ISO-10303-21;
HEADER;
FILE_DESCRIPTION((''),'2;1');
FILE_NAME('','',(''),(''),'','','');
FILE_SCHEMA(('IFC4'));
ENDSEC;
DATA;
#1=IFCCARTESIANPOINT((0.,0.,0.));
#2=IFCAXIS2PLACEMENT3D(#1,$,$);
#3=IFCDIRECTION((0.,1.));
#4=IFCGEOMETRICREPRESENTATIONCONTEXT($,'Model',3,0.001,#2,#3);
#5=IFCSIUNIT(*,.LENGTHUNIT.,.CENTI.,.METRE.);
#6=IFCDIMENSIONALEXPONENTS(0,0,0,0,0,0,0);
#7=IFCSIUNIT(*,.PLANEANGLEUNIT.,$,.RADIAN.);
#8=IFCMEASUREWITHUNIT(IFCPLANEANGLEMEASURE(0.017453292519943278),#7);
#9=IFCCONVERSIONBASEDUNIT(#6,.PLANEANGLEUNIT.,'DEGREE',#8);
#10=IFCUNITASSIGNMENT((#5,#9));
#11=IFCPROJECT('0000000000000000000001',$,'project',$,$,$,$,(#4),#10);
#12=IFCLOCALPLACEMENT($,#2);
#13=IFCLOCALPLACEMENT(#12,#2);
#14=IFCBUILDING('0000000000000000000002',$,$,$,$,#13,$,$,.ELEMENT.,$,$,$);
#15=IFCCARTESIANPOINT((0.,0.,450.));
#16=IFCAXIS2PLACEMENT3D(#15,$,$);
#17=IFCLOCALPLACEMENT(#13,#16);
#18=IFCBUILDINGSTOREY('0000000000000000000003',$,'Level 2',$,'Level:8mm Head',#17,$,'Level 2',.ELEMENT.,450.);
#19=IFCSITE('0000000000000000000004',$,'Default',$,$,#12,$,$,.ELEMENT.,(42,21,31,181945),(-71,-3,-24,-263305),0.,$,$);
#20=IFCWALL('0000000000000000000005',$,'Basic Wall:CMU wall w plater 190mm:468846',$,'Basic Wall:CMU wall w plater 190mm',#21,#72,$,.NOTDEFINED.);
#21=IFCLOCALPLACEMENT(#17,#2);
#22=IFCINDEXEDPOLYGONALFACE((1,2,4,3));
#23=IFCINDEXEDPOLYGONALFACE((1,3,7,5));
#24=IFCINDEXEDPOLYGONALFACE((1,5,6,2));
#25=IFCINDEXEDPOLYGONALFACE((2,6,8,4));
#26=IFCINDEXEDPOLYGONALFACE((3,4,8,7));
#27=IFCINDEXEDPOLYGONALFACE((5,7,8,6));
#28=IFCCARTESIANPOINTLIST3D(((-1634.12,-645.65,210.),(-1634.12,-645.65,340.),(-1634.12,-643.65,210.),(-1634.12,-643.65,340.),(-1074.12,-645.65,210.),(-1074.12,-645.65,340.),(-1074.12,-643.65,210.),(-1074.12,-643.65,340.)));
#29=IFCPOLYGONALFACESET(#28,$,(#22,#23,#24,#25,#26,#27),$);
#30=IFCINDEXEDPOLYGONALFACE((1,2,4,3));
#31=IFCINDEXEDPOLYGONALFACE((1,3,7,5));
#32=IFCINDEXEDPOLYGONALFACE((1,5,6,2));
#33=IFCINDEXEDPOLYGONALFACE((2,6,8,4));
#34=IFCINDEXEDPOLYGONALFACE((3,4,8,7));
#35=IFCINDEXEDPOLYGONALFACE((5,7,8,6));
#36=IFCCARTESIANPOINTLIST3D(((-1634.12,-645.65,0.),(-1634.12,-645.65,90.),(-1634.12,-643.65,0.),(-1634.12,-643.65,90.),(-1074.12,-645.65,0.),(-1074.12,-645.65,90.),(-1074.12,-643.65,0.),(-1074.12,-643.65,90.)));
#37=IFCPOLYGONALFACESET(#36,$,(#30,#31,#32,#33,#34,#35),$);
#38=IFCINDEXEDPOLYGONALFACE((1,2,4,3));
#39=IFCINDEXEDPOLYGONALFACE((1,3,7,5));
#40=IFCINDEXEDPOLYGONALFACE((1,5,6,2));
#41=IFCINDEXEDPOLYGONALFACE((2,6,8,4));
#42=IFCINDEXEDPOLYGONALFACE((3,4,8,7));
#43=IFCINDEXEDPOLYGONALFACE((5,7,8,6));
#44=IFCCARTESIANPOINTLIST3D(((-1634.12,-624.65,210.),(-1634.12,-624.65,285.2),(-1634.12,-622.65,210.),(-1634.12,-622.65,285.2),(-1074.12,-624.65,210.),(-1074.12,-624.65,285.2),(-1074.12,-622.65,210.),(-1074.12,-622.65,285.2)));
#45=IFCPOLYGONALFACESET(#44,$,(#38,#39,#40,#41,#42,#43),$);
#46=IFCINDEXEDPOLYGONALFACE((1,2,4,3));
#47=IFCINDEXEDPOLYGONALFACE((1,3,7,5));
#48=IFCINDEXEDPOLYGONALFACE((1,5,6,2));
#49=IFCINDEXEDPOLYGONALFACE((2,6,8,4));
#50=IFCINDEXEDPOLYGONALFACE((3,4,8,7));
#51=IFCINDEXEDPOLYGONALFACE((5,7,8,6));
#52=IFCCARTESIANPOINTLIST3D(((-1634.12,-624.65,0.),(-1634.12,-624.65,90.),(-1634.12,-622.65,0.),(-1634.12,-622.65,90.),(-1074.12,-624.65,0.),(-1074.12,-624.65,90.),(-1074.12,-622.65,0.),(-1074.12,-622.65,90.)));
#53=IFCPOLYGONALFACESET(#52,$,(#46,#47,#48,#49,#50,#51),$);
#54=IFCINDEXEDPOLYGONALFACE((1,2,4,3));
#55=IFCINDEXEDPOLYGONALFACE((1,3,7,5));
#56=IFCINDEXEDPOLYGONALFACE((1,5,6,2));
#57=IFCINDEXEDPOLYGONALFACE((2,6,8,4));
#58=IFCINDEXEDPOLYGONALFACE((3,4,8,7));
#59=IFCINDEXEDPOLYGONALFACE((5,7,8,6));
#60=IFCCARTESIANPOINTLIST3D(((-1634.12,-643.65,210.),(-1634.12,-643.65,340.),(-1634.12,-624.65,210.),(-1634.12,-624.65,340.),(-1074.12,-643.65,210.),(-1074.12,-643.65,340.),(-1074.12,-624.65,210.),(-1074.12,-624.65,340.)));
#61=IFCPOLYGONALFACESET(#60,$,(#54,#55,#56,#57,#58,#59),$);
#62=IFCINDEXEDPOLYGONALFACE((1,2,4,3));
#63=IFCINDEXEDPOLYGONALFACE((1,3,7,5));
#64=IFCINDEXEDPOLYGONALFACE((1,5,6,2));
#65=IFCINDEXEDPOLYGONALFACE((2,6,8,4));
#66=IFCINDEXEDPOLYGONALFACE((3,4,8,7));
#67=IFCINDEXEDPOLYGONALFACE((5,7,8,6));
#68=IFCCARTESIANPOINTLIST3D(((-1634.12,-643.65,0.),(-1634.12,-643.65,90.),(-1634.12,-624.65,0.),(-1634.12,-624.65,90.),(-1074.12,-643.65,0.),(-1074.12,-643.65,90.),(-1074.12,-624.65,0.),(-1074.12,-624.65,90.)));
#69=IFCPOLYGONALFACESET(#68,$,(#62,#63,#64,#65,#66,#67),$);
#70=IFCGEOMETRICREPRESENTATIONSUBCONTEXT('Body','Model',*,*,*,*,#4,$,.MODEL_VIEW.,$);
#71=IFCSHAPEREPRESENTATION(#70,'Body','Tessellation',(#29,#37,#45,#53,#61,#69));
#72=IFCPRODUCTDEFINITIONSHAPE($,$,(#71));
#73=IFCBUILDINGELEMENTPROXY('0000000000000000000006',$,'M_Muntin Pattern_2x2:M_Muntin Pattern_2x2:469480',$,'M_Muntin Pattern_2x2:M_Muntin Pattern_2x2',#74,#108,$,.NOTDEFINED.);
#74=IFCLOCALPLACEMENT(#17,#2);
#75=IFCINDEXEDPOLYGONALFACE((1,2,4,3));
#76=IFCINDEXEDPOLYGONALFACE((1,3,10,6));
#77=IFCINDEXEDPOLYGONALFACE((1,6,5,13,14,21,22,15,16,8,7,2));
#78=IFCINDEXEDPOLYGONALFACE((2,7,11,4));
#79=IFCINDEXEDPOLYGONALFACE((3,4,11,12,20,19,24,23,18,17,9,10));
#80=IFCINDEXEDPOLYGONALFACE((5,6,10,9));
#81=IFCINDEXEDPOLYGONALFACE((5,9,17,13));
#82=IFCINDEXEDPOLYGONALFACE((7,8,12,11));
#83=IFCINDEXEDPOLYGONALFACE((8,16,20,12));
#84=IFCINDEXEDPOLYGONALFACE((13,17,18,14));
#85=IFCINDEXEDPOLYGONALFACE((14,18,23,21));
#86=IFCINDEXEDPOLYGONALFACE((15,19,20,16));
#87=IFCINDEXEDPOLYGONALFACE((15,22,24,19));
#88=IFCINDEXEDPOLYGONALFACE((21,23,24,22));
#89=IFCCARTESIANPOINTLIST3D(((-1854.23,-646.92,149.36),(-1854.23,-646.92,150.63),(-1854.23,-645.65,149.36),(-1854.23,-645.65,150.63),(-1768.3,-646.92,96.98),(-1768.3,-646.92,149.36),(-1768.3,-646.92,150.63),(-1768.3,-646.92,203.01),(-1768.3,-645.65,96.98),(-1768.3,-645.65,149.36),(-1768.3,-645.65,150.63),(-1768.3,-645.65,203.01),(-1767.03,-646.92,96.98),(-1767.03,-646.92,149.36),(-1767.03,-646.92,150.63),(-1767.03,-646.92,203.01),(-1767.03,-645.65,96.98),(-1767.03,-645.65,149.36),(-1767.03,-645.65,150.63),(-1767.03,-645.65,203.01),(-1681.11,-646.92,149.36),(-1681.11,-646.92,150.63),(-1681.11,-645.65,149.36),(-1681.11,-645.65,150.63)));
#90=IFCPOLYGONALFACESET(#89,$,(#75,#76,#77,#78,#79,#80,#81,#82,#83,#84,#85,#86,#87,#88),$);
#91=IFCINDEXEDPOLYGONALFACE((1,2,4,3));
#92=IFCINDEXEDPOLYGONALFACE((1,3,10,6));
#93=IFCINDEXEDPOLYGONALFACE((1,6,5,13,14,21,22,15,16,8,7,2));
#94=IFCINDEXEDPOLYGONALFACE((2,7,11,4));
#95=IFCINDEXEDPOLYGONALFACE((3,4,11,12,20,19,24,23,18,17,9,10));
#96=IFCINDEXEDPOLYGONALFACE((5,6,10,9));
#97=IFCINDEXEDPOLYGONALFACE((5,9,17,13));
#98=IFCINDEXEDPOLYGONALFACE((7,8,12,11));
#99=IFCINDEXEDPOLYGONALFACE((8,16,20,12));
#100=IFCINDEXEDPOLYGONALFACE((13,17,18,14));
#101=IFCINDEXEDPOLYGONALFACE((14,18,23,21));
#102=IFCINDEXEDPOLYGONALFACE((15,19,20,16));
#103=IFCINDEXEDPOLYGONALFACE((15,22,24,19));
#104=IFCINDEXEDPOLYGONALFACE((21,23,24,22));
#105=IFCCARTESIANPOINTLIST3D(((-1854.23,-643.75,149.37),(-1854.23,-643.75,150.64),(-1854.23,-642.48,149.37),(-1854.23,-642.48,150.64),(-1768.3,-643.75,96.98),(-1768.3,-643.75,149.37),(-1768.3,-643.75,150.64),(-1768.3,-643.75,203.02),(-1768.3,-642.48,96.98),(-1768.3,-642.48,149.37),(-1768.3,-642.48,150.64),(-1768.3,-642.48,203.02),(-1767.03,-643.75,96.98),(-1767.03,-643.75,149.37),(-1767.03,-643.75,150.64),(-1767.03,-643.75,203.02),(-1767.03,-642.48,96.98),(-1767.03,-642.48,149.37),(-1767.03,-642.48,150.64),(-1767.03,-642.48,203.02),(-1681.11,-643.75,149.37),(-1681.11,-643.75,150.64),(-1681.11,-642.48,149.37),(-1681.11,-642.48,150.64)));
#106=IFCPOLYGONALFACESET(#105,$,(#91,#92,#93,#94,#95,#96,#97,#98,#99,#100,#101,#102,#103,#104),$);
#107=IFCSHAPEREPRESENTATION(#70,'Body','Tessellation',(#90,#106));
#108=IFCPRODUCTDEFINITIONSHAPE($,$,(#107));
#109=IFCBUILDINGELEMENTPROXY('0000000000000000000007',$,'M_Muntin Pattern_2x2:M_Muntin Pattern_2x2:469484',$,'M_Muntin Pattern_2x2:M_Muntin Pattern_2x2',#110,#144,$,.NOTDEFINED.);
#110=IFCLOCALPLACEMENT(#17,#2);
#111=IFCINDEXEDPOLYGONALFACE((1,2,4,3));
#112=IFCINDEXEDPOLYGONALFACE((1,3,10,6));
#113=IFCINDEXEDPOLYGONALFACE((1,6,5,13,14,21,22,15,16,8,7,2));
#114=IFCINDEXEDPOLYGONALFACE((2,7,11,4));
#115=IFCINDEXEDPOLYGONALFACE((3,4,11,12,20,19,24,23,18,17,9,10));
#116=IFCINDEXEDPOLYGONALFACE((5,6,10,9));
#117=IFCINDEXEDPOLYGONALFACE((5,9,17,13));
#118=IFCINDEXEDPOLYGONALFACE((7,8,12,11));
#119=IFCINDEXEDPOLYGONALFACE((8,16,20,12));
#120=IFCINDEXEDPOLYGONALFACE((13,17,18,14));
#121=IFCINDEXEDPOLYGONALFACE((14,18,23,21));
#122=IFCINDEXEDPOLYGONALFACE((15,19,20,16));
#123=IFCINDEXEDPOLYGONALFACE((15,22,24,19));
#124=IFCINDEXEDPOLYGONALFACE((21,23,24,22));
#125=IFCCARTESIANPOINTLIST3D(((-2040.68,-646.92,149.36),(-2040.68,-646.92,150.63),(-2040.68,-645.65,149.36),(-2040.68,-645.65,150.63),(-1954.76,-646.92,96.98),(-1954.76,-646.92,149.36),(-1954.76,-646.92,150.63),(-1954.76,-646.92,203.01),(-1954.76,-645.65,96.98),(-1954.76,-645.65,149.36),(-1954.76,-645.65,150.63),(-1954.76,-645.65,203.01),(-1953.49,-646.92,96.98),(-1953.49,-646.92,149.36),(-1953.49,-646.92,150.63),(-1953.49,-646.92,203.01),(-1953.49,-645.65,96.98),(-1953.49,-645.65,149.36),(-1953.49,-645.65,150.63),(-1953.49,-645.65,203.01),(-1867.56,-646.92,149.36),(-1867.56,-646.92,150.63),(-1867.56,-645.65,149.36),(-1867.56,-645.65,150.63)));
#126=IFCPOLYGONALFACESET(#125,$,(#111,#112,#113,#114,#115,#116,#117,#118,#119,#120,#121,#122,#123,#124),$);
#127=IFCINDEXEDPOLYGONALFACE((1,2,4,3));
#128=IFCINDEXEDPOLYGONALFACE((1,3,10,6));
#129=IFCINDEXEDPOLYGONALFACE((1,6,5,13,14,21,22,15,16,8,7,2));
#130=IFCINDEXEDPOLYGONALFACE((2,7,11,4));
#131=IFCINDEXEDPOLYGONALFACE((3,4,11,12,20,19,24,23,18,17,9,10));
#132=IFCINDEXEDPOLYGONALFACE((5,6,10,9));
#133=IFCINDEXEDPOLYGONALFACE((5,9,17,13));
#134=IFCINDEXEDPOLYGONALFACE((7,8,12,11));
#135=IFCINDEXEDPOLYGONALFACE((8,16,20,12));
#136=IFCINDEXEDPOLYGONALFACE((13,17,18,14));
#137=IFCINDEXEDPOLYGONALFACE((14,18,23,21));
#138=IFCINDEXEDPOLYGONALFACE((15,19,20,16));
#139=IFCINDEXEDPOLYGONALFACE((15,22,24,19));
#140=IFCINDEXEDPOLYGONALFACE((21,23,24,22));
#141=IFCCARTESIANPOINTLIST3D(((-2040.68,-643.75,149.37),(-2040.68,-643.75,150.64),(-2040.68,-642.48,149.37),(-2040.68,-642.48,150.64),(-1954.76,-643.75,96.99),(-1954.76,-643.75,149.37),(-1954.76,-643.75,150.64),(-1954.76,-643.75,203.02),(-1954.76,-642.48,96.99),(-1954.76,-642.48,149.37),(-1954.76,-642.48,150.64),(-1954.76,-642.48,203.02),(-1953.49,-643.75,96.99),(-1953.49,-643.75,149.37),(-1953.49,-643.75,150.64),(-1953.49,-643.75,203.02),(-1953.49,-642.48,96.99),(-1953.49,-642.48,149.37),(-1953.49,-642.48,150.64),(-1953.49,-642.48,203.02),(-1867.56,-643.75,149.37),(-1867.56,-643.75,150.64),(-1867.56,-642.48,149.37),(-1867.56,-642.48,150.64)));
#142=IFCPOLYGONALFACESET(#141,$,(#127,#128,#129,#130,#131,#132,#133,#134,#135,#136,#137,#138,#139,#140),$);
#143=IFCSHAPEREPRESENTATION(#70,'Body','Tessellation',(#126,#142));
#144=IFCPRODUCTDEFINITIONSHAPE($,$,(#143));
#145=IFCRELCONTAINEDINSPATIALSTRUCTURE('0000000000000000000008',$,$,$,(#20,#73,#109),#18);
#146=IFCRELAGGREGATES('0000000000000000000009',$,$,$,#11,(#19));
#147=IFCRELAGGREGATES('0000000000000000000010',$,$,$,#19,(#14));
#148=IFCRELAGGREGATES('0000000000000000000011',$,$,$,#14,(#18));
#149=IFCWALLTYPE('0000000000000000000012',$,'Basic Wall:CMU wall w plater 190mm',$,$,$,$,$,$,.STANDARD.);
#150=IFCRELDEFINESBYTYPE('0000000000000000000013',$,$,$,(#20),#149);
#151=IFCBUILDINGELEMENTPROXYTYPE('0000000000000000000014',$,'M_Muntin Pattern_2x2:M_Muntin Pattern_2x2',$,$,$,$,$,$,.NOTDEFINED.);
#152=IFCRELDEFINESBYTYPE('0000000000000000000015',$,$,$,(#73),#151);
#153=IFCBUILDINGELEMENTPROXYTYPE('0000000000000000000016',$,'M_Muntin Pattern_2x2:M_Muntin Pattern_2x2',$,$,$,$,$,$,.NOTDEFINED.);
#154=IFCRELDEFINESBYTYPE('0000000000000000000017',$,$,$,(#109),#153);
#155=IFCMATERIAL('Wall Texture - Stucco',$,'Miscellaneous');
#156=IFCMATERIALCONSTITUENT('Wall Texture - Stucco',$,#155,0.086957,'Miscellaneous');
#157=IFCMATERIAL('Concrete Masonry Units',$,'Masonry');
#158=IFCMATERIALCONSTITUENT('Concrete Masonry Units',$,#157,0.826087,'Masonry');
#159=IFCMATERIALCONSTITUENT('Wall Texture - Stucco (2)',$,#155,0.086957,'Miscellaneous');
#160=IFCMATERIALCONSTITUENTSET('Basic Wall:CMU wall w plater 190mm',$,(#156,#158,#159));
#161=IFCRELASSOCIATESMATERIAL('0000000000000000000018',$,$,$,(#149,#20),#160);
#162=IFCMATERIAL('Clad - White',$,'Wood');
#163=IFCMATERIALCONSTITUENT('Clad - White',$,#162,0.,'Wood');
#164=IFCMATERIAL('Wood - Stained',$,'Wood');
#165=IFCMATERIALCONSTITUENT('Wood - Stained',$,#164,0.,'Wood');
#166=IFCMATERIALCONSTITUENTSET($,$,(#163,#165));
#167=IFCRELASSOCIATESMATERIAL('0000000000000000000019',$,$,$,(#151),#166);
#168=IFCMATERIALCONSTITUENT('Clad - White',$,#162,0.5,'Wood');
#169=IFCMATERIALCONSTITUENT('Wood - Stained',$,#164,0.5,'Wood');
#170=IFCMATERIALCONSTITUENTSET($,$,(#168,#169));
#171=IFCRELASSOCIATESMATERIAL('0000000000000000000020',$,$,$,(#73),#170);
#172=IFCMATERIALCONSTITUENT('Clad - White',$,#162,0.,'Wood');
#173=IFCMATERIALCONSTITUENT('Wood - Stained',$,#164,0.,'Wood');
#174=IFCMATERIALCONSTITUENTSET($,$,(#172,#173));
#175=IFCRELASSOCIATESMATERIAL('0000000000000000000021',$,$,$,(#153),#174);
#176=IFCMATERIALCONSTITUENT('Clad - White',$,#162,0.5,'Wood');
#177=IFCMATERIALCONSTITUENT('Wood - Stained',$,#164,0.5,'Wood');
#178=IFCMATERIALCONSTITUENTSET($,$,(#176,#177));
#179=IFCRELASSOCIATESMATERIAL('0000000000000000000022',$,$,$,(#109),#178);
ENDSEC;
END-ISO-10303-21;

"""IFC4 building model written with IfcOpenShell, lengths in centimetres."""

from ifc_helpers import new_model, entity, si_unit, converted_unit, direction, frame, origin, place, context, subcontext, project, spatial, indexed_curve, outline, extrude, source, transform, mapped, material, constituent, constituent_set, type_object, type_shapes, element, save


model = new_model("IFC4")

# Units and contexts
model_context = context("Model", 3, precision=0.001, world=origin(), true_north=direction((0.0, 1.0)))
body_context = subcontext(model_context, "Body", "Model", "MODEL_VIEW")
ifc_project = project(units=[si_unit("LENGTHUNIT", "METRE", prefix="CENTI"), converted_unit("PLANEANGLEUNIT", "DEGREE", entity("IfcPlaneAngleMeasure", 0.017453292519943278), si_unit("PLANEANGLEUNIT", "RADIAN"), dimensions=[0, 0, 0, 0, 0, 0, 0])], contexts=[model_context])

# Site, building, storey
site_placement = place(None, origin())
site = spatial("IfcSite", under=ifc_project, at=site_placement, Name="Default", CompositionType="ELEMENT", RefLatitude=(42, 21, 31, 181945), RefLongitude=(-71, -3, -24, -263305), RefElevation=0.0)
building_placement = place(site_placement, origin())
building = spatial("IfcBuilding", under=site, at=building_placement, CompositionType="ELEMENT")
storey_placement = place(building_placement, frame((0.0, 0.0, 450.0)))
storey = spatial("IfcBuildingStorey", under=building, at=storey_placement, Name="Level 2", ObjectType="Level:8mm Head", LongName="Level 2", CompositionType="ELEMENT", Elevation=450.0)

# Wall, opening
ifc_material_1 = material(Name="Wall Texture - Stucco", Category="Miscellaneous")
ifc_constituent_1 = constituent(ifc_material_1, Name="Wall Texture - Stucco", Category="Miscellaneous", fraction=0.086957)
ifc_material_2 = material(Name="Concrete Masonry Units", Category="Masonry")
ifc_constituent_2 = constituent(ifc_material_2, Name="Concrete Masonry Units", Category="Masonry", fraction=0.826087)
ifc_constituent_3 = constituent(ifc_material_1, Name="Wall Texture - Stucco (2)", Category="Miscellaneous", fraction=0.086957)
ifc_constituent_set_1 = constituent_set(constituents=[ifc_constituent_1, ifc_constituent_2, ifc_constituent_3], Name="Basic Wall:CMU wall w plater 190mm")
wall_type_1 = type_object("IfcWallType", Name="Basic Wall:CMU wall w plater 190mm", PredefinedType="STANDARD", material=ifc_constituent_set_1)
wall_1_placement = place(storey_placement, frame((-1634.12, -634.15, 0.0)))
wall_1 = element("IfcWall", 1, at=wall_1_placement, inside=storey, type_object=wall_type_1, material=ifc_constituent_set_1, Name="Basic Wall:CMU wall w plater 190mm:468846", ObjectType="Basic Wall:CMU wall w plater 190mm", PredefinedType="NOTDEFINED", context=body_context, shape_type="SweptSolid", body=[
    extrude(outline(indexed_curve([(-278.0, -0.67), (278.0, -0.67), (280.0, -0.67), (280.0, 1.33), (-280.0, 1.33), (-280.0, -0.67), (-278.0, -0.67)], self_intersect=False)), frame((280.0, -10.83, 210.0)), (0.0, 0.0, 1.0), 130.0),
    extrude(outline(indexed_curve([(-1.0, -280.0), (1.0, -280.0), (1.0, 280.0), (-1.0, 280.0), (-1.0, -280.0)], self_intersect=False)), frame((280.0, -10.5, 0.0), z_axis=(0.0, 0.0, 1.0), x_axis=(0.0, 1.0, 0.0)), (0.0, 0.0, 1.0), 90.0),
    extrude(outline(indexed_curve([(-1.0, -37.6), (1.0, -37.6), (1.0, 37.6), (-1.0, 37.6), (-1.0, -37.6)], self_intersect=False)), frame((0.0, 10.5, 247.6), z_axis=(1.0, 0.0, 0.0), x_axis=(0.0, -1.0, 0.0)), (0.0, 0.0, 1.0), 560.0),
    extrude(outline(indexed_curve([(-1.0, -280.0), (1.0, -280.0), (1.0, 280.0), (-1.0, 280.0), (-1.0, -280.0)], self_intersect=False)), frame((280.0, 10.5, 0.0), z_axis=(0.0, 0.0, 1.0), x_axis=(0.0, -1.0, 0.0)), (0.0, 0.0, 1.0), 90.0),
    extrude(outline(indexed_curve([(-280.0, -9.5), (280.0, -9.5), (280.0, 9.5), (-280.0, 9.5), (-280.0, -9.5)], self_intersect=False)), frame((280.0, 0.0, 210.0), z_axis=(0.0, 0.0, 1.0), x_axis=(-1.0, 0.0, 0.0)), (0.0, 0.0, 1.0), 130.0),
    extrude(outline(indexed_curve([(-280.0, -9.5), (280.0, -9.5), (280.0, 9.5), (-280.0, 9.5), (-280.0, -9.5)], self_intersect=False)), frame((280.0, 0.0, 0.0)), (0.0, 0.0, 1.0), 90.0),
])
opening_1_placement = place(wall_1_placement, frame((560.0, 11.5, 90.0)))
element("IfcOpeningElement", 2, at=opening_1_placement, cuts=wall_1, PredefinedType="OPENING", context=body_context, shape_type="SweptSolid", body=[
    extrude(outline(indexed_curve([(120.0, 560.0), (0.0, 560.0), (0.0, 0.0), (120.0, 0.0), (120.0, 560.0)], self_intersect=False)), frame((0.0, 0.0, 0.0), z_axis=(0.0, -1.0, 0.0), x_axis=(0.0, 0.0, 1.0)), (0.0, 0.0, 1.0), 23.0),
])

# Building element proxies
ifc_material_3 = material(Name="Clad - White", Category="Wood")
ifc_constituent_4 = constituent(ifc_material_3, Name="Clad - White", Category="Wood", fraction=0.5)
ifc_material_4 = material(Name="Wood - Stained", Category="Wood")
ifc_constituent_5 = constituent(ifc_material_4, Name="Wood - Stained", Category="Wood", fraction=0.5)
ifc_constituent_set_2 = constituent_set(constituents=[ifc_constituent_4, ifc_constituent_5])
ifc_constituent_6 = constituent(ifc_material_3, Name="Clad - White", Category="Wood", fraction=0.0)
ifc_constituent_7 = constituent(ifc_material_4, Name="Wood - Stained", Category="Wood", fraction=0.0)
ifc_constituent_set_3 = constituent_set(constituents=[ifc_constituent_6, ifc_constituent_7])
building_element_proxy_type_1 = type_object("IfcBuildingElementProxyType", Name="M_Muntin Pattern_2x2:M_Muntin Pattern_2x2", PredefinedType="NOTDEFINED", material=ifc_constituent_set_3)
shared_shape_1 = source(origin(), body_context, "Body", "SweptSolid", [
    extrude(outline(indexed_curve([(0.64, -0.64), (53.01, -0.64), (53.01, 0.63), (0.64, 0.63), (0.64, 86.56), (-0.63, 86.56), (-0.63, 0.63), (-53.02, 0.63), (-53.02, -0.64), (-0.63, -0.64), (-0.63, -86.56), (0.64, -86.56), (0.64, -0.64)], self_intersect=False)), frame((0.0, 0.95, 53.01), z_axis=(0.0, 1.0, 0.0), x_axis=(0.0, 0.0, 1.0)), (0.0, 0.0, 1.0), 1.27),
    extrude(outline(indexed_curve([(0.64, -0.64), (53.02, -0.64), (53.02, 0.63), (0.64, 0.63), (0.64, 86.56), (-0.63, 86.56), (-0.63, 0.63), (-53.02, 0.63), (-53.02, -0.64), (-0.63, -0.64), (-0.63, -86.56), (0.64, -86.56), (0.64, -0.64)], self_intersect=False)), frame((0.0, -2.22, 53.02), z_axis=(0.0, 1.0, 0.0), x_axis=(0.0, 0.0, 1.0)), (0.0, 0.0, 1.0), 1.27),
])
type_shapes(building_element_proxy_type_1, [shared_shape_1])
proxy_1_placement = place(storey_placement, frame((-1767.67, -644.7, 96.98), z_axis=(0.0, 0.0, 1.0), x_axis=(-1.0, 0.0, 0.0)))
element("IfcBuildingElementProxy", 3, at=proxy_1_placement, inside=storey, type_object=building_element_proxy_type_1, material=ifc_constituent_set_2, Name="M_Muntin Pattern_2x2:M_Muntin Pattern_2x2:469480", ObjectType="M_Muntin Pattern_2x2:M_Muntin Pattern_2x2", PredefinedType="NOTDEFINED", context=body_context, shape_type="MappedRepresentation", body=[
    mapped(shared_shape_1, transform((0.0, 0.0, 0.0), scale=1.0)),
])
ifc_constituent_8 = constituent(ifc_material_3, Name="Clad - White", Category="Wood", fraction=0.5)
ifc_constituent_9 = constituent(ifc_material_4, Name="Wood - Stained", Category="Wood", fraction=0.5)
ifc_constituent_set_4 = constituent_set(constituents=[ifc_constituent_8, ifc_constituent_9])
ifc_constituent_10 = constituent(ifc_material_3, Name="Clad - White", Category="Wood", fraction=0.0)
ifc_constituent_11 = constituent(ifc_material_4, Name="Wood - Stained", Category="Wood", fraction=0.0)
ifc_constituent_set_5 = constituent_set(constituents=[ifc_constituent_10, ifc_constituent_11])
building_element_proxy_type_2 = type_object("IfcBuildingElementProxyType", Name="M_Muntin Pattern_2x2:M_Muntin Pattern_2x2", PredefinedType="NOTDEFINED", material=ifc_constituent_set_5)
shared_shape_2 = source(origin(), body_context, "Body", "SweptSolid", [
    extrude(outline(indexed_curve([(0.64, -0.64), (53.01, -0.64), (53.01, 0.63), (0.64, 0.63), (0.64, 86.56), (-0.63, 86.56), (-0.63, 0.63), (-53.02, 0.63), (-53.02, -0.64), (-0.63, -0.64), (-0.63, -86.56), (0.64, -86.56), (0.64, -0.64)], self_intersect=False)), frame((0.0, -2.22, 53.01), z_axis=(0.0, 1.0, 0.0), x_axis=(0.0, 0.0, 1.0)), (0.0, 0.0, 1.0), 1.27),
    extrude(outline(indexed_curve([(0.64, -0.64), (53.02, -0.64), (53.02, 0.63), (0.64, 0.63), (0.64, 86.56), (-0.63, 86.56), (-0.63, 0.63), (-53.02, 0.63), (-53.02, -0.64), (-0.63, -0.64), (-0.63, -86.56), (0.64, -86.56), (0.64, -0.64)], self_intersect=False)), frame((0.0, 0.95, 53.02), z_axis=(0.0, 1.0, 0.0), x_axis=(0.0, 0.0, 1.0)), (0.0, 0.0, 1.0), 1.27),
])
type_shapes(building_element_proxy_type_2, [shared_shape_2])
proxy_2_placement = place(storey_placement, frame((-1954.12, -644.7, 96.99)))
element("IfcBuildingElementProxy", 4, at=proxy_2_placement, inside=storey, type_object=building_element_proxy_type_2, material=ifc_constituent_set_4, Name="M_Muntin Pattern_2x2:M_Muntin Pattern_2x2:469484", ObjectType="M_Muntin Pattern_2x2:M_Muntin Pattern_2x2", PredefinedType="NOTDEFINED", context=body_context, shape_type="MappedRepresentation", body=[
    mapped(shared_shape_2, transform((0.0, 0.0, 0.0), scale=1.0)),
])

save(model, "model.ifc")
